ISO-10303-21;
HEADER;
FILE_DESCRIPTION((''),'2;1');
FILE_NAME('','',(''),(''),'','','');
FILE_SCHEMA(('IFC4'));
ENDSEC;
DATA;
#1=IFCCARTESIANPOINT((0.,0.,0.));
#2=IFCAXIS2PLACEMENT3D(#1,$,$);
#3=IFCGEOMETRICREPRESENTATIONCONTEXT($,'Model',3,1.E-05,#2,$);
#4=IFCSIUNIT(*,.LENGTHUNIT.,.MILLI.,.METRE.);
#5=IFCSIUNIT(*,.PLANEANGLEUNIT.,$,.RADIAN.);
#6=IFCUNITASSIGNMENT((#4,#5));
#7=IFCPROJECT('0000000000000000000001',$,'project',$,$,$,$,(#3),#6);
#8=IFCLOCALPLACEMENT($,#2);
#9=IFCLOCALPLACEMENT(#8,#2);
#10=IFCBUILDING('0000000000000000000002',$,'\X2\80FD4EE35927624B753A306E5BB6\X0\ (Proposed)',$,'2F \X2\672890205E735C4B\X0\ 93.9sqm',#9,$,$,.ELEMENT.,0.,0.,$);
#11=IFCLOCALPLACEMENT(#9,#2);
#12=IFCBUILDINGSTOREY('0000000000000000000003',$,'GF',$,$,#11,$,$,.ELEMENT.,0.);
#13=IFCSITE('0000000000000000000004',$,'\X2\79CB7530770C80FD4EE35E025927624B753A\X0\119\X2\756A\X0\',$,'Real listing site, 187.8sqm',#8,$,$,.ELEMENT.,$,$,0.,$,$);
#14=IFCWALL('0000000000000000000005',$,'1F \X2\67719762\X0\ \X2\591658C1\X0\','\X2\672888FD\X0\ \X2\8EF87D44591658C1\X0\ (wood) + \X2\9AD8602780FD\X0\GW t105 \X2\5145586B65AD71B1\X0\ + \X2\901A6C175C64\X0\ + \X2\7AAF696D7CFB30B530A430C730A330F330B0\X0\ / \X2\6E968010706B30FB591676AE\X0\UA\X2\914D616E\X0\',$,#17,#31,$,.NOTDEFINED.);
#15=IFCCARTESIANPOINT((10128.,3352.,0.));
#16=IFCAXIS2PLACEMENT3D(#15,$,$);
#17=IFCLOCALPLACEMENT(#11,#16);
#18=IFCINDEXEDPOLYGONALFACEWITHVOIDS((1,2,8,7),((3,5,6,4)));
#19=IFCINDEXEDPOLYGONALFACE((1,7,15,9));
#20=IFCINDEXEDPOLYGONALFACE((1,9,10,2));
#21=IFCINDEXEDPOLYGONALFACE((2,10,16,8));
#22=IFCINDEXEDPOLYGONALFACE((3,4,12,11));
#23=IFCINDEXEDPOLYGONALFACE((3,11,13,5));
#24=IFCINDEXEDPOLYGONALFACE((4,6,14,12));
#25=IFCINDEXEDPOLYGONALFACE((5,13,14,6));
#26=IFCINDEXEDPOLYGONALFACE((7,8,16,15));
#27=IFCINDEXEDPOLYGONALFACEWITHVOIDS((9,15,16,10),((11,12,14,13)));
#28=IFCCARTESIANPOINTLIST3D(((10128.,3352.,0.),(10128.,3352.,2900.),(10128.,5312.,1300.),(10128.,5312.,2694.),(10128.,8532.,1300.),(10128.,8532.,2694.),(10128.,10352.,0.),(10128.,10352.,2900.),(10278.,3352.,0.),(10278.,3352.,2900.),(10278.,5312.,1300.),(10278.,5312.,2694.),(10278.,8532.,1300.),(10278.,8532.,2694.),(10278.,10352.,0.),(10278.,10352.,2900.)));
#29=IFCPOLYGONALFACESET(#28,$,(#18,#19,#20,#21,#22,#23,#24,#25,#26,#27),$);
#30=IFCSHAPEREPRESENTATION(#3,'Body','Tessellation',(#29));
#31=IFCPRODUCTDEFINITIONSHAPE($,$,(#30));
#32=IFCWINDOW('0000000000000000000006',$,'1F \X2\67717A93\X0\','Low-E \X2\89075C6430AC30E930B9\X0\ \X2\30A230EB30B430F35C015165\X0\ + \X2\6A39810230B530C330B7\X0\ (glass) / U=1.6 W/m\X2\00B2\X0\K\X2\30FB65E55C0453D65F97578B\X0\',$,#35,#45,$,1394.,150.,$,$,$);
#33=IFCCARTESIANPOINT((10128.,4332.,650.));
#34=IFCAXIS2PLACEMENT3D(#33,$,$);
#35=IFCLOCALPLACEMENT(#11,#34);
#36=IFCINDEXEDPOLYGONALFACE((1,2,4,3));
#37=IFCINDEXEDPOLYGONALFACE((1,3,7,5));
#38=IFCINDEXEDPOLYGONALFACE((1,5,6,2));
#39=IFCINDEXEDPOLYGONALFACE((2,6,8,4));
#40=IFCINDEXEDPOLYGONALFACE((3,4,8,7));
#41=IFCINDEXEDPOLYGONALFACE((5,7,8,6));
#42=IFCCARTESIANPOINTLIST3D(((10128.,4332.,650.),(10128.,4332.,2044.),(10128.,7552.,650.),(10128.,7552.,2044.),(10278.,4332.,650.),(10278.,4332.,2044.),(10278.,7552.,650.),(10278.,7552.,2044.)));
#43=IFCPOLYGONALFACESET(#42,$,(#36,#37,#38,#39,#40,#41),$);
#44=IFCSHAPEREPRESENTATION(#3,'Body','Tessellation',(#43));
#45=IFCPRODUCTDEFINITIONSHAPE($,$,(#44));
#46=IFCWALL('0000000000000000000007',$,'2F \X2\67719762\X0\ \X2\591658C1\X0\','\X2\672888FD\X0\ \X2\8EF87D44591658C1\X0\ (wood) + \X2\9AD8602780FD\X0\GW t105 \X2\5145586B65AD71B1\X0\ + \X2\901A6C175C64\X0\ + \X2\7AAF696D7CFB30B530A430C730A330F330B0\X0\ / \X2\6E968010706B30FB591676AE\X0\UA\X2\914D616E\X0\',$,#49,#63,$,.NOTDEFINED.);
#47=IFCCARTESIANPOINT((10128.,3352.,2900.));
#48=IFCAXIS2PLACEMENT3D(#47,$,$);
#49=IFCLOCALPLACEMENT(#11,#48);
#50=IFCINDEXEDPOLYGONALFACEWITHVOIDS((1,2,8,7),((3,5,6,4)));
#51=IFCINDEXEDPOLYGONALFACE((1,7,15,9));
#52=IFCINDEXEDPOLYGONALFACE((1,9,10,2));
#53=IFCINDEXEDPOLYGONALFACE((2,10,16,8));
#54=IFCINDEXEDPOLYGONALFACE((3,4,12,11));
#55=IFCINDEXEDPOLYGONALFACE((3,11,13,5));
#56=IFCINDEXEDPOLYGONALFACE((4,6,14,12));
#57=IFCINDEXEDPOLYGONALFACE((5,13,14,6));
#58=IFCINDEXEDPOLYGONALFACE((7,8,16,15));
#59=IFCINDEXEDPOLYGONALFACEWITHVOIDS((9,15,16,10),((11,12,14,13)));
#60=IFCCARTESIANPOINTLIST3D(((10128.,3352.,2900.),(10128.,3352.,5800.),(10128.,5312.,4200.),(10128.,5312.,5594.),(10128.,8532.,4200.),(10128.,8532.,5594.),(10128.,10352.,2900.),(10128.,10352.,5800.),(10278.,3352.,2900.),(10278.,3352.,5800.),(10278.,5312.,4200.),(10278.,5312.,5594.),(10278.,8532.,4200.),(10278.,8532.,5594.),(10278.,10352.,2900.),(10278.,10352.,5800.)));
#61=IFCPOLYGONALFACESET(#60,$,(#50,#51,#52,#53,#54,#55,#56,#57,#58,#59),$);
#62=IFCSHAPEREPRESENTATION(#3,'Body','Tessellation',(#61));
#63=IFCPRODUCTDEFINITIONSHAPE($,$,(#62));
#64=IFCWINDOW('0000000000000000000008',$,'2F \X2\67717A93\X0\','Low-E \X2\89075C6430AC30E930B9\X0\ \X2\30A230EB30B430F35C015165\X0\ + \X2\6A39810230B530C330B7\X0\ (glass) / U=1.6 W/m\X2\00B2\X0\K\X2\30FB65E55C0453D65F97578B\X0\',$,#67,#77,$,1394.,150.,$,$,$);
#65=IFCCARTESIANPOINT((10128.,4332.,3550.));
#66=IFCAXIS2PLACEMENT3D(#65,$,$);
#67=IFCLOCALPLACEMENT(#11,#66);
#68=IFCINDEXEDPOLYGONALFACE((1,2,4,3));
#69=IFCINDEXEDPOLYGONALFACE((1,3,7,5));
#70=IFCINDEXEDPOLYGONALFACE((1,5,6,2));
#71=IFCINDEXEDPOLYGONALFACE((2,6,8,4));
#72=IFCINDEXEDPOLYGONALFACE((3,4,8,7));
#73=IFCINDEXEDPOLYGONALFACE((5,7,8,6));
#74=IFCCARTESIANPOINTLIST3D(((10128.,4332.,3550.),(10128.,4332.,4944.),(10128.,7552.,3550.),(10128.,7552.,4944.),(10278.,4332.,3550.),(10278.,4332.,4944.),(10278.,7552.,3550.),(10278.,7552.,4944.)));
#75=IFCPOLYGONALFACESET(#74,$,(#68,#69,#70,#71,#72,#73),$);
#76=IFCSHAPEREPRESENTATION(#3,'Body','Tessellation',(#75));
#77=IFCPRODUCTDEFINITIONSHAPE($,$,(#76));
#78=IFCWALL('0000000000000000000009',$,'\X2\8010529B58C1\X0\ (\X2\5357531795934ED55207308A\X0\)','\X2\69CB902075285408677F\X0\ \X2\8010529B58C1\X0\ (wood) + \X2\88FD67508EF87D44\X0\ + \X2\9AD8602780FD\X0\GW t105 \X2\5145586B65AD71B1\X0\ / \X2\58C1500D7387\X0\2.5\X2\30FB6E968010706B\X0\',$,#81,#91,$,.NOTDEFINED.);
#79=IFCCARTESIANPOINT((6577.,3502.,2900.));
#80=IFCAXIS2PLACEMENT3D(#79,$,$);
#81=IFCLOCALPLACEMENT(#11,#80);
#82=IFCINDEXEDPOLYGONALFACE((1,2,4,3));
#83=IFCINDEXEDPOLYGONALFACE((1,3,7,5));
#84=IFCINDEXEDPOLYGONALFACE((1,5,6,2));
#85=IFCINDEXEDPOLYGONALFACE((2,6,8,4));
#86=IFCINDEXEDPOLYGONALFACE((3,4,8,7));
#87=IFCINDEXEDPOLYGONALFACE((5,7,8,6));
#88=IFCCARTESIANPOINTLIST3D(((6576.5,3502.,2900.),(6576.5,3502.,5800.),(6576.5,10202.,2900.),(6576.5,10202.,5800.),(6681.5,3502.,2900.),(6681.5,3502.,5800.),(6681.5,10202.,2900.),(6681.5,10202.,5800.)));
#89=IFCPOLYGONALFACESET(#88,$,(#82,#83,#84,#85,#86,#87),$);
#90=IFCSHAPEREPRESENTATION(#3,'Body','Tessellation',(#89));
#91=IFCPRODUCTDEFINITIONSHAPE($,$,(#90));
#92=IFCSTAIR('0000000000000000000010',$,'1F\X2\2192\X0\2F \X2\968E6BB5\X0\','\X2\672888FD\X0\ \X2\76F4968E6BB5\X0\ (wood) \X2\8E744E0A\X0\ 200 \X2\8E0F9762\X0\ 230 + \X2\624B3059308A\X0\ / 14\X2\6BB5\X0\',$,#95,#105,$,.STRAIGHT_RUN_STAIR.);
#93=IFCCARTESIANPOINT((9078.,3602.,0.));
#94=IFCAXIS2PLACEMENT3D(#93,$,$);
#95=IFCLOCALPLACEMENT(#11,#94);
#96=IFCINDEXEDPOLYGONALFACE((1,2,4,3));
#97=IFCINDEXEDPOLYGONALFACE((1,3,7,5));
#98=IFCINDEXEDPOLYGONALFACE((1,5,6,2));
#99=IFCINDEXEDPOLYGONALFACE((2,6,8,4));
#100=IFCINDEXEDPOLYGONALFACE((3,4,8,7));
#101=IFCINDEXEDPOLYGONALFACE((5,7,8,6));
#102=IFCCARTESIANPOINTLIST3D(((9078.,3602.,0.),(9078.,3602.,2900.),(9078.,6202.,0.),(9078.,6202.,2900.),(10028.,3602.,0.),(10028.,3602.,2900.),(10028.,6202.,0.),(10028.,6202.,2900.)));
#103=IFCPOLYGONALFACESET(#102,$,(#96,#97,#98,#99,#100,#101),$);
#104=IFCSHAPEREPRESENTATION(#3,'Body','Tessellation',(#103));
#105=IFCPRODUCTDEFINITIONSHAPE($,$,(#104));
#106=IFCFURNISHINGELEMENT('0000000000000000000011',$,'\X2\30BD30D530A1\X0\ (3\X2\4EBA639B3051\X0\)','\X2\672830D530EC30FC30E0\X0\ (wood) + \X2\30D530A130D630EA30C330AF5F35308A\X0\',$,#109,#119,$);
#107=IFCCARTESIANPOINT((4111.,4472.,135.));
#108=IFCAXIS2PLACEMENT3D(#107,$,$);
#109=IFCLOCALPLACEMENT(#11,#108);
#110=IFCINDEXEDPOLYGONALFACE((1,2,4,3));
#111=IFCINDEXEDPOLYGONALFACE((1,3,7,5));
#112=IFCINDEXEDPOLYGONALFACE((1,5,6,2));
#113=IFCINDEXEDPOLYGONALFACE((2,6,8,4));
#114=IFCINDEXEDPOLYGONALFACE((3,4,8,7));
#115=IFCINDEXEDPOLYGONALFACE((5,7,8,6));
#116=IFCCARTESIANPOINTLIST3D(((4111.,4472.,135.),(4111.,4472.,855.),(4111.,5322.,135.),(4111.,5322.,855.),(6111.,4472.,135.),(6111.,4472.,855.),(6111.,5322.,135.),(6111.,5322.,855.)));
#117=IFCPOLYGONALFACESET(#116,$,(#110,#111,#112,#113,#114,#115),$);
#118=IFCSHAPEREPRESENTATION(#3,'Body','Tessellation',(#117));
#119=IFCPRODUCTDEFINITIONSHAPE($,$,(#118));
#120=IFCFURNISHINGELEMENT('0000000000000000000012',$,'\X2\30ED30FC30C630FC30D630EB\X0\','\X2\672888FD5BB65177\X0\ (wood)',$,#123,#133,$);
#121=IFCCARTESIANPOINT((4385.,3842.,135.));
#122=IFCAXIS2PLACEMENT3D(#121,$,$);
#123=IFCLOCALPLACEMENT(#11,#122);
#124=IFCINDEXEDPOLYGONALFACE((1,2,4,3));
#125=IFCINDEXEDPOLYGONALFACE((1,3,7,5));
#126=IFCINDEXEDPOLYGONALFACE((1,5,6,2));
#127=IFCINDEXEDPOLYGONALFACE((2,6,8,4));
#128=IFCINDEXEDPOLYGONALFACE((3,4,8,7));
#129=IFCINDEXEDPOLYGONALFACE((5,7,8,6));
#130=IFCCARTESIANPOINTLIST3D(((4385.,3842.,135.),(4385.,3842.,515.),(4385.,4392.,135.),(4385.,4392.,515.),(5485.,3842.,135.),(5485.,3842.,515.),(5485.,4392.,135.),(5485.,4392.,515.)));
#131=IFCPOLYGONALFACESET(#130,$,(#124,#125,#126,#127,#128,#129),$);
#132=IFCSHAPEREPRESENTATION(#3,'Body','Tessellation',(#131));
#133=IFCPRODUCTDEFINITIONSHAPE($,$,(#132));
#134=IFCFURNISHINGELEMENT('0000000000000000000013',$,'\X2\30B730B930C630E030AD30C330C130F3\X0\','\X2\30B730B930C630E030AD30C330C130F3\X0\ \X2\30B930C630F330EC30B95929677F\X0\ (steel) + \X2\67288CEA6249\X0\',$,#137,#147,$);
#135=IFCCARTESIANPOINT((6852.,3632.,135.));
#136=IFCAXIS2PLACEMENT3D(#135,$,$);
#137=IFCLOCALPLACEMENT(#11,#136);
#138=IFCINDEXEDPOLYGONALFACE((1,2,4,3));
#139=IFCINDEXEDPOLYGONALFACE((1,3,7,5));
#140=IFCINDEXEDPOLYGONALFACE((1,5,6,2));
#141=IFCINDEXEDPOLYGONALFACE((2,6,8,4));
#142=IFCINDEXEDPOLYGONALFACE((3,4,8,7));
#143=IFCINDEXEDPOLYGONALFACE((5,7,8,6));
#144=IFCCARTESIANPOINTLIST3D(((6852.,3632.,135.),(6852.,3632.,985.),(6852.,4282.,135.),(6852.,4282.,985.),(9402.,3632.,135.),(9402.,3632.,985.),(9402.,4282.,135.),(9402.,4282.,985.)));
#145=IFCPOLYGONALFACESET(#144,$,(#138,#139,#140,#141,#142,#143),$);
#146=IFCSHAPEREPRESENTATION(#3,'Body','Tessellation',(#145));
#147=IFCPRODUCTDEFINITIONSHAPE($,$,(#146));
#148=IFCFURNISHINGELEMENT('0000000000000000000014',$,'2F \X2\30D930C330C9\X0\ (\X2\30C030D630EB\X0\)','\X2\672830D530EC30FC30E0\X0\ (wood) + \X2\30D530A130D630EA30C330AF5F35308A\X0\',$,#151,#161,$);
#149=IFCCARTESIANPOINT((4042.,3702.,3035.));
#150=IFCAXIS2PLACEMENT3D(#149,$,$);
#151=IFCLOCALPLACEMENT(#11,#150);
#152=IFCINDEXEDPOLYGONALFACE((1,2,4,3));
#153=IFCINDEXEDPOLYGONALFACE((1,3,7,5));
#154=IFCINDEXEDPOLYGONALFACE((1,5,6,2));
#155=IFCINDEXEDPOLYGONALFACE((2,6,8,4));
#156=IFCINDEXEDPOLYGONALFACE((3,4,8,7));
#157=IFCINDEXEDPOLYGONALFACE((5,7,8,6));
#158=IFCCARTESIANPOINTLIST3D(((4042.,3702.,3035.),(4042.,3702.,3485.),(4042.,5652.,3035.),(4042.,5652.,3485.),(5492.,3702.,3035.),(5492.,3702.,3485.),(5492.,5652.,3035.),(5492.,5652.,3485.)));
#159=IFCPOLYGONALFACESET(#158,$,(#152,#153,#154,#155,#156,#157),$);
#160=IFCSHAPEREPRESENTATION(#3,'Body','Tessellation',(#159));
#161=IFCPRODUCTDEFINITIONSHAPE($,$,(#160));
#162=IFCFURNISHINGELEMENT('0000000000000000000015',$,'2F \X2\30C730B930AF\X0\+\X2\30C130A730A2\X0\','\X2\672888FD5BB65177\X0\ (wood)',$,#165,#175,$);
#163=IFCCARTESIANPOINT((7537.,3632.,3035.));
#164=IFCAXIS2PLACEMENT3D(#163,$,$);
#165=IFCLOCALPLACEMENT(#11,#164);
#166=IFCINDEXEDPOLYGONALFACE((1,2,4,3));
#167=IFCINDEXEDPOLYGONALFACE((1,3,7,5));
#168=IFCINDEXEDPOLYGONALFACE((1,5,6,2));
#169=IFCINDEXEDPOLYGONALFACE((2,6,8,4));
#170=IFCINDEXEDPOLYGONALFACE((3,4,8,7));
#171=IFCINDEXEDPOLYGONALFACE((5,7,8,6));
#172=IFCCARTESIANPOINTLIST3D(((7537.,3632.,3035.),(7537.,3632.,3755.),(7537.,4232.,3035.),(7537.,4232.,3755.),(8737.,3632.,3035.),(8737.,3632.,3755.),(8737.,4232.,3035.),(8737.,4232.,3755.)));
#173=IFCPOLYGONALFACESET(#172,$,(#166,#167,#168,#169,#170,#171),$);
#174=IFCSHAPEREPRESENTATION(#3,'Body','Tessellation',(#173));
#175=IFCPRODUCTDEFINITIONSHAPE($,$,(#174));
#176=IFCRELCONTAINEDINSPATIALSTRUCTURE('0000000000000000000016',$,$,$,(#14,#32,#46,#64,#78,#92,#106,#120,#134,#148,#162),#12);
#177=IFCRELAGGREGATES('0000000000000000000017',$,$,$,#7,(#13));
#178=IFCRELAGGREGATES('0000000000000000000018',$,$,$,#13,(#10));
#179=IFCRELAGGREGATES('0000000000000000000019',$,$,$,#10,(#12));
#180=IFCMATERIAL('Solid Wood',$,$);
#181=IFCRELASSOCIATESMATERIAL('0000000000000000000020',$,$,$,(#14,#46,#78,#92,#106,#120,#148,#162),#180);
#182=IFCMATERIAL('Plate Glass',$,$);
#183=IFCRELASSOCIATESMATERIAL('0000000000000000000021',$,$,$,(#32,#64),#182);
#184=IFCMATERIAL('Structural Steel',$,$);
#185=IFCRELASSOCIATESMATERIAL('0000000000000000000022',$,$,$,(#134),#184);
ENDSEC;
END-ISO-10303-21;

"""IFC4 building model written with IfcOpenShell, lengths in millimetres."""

from ifc_helpers import new_model, si_unit, frame, frame_2d, origin, place, context, project, spatial, rectangle, extrude, material, element, fill, save


model = new_model("IFC4")

# Units and contexts
model_context = context("Model", 3, precision=1e-05, world=origin())
ifc_project = project(units=[si_unit("LENGTHUNIT", "METRE", prefix="MILLI"), si_unit("PLANEANGLEUNIT", "RADIAN")], contexts=[model_context])

# Site, building, storey
site_placement = place(None, origin())
site = spatial("IfcSite", under=ifc_project, at=site_placement, Name="秋田県能代市大手町119番", ObjectType="Real listing site, 187.8sqm", CompositionType="ELEMENT", RefElevation=0.0)
building_placement = place(site_placement, origin())
building = spatial("IfcBuilding", under=site, at=building_placement, Name="能代大手町の家 (Proposed)", ObjectType="2F 木造平屋 93.9sqm", CompositionType="ELEMENT", ElevationOfRefHeight=0.0, ElevationOfTerrain=0.0)
storey_placement = place(building_placement, origin())
storey = spatial("IfcBuildingStorey", under=building, at=storey_placement, Name="GF", CompositionType="ELEMENT", Elevation=0.0)

# Wall, opening, window
ifc_material_1 = material(Name="Solid Wood")
wall_1_placement = place(storey_placement, frame((10128.0, 3352.0, 0.0)))
wall_1 = element("IfcWall", 1, at=wall_1_placement, inside=storey, material=ifc_material_1, Name="1F 東面 外壁", Description="木製 軸組外壁 (wood) + 高性能GW t105 充填断熱 + 通気層 + 窯業系サイディング / 準耐火・外皮UA配慮", PredefinedType="NOTDEFINED", context=model_context, shape_type="SweptSolid", body=[
    extrude(rectangle(XDim=150.0, YDim=7000.0, at=frame_2d((75.0, 3500.0))), frame((10128.0, 3352.0, 0.0)), (0.0, 0.0, 1.0), 2900.0),
])
opening_1_placement = place(storey_placement, frame((10128.0, 4332.0, 650.0)))
opening_1 = element("IfcOpeningElement", 2, at=opening_1_placement, cuts=wall_1, PredefinedType="NOTDEFINED", context=model_context, shape_type="SweptSolid", body=[
    extrude(rectangle(XDim=150.0, YDim=3220.0, at=frame_2d((75.0, 1610.0))), frame((10128.0, 4332.0, 650.0)), (0.0, 0.0, 1.0), 1394.0),
])
ifc_material_2 = material(Name="Plate Glass")
window_1_placement = place(storey_placement, frame((10128.0, 4332.0, 650.0)))
window_1 = element("IfcWindow", 3, at=window_1_placement, inside=storey, material=ifc_material_2, Name="1F 東窓", Description="Low-E 複層ガラス アルゴン封入 + 樹脂サッシ (glass) / U=1.6 W/m²K・日射取得型", OverallHeight=1394.0, OverallWidth=150.0, context=model_context, shape_type="SweptSolid", body=[
    extrude(rectangle(XDim=150.0, YDim=3220.0, at=frame_2d((75.0, 1610.0))), frame((10128.0, 4332.0, 650.0)), (0.0, 0.0, 1.0), 1394.0),
])
fill(opening_1, window_1)

# Wall, opening, window
wall_2_placement = place(storey_placement, frame((10128.0, 3352.0, 2900.0)))
wall_2 = element("IfcWall", 4, at=wall_2_placement, inside=storey, material=ifc_material_1, Name="2F 東面 外壁", Description="木製 軸組外壁 (wood) + 高性能GW t105 充填断熱 + 通気層 + 窯業系サイディング / 準耐火・外皮UA配慮", PredefinedType="NOTDEFINED", context=model_context, shape_type="SweptSolid", body=[
    extrude(rectangle(XDim=150.0, YDim=7000.0, at=frame_2d((75.0, 3500.0))), frame((10128.0, 3352.0, 2900.0)), (0.0, 0.0, 1.0), 2900.0),
])
opening_2_placement = place(storey_placement, frame((10128.0, 4332.0, 3550.0)))
opening_2 = element("IfcOpeningElement", 5, at=opening_2_placement, cuts=wall_2, PredefinedType="NOTDEFINED", context=model_context, shape_type="SweptSolid", body=[
    extrude(rectangle(XDim=150.0, YDim=3220.0, at=frame_2d((75.0, 1610.0))), frame((10128.0, 4332.0, 3550.0)), (0.0, 0.0, 1.0), 1394.0),
])
window_2_placement = place(storey_placement, frame((10128.0, 4332.0, 3550.0)))
window_2 = element("IfcWindow", 6, at=window_2_placement, inside=storey, material=ifc_material_2, Name="2F 東窓", Description="Low-E 複層ガラス アルゴン封入 + 樹脂サッシ (glass) / U=1.6 W/m²K・日射取得型", OverallHeight=1394.0, OverallWidth=150.0, context=model_context, shape_type="SweptSolid", body=[
    extrude(rectangle(XDim=150.0, YDim=3220.0, at=frame_2d((75.0, 1610.0))), frame((10128.0, 4332.0, 3550.0)), (0.0, 0.0, 1.0), 1394.0),
])
fill(opening_2, window_2)

# Wall
wall_3_placement = place(storey_placement, frame((6577.0, 3502.0, 2900.0)))
element("IfcWall", 7, at=wall_3_placement, inside=storey, material=ifc_material_1, Name="耐力壁 (南北間仕切り)", Description="構造用合板 耐力壁 (wood) + 製材軸組 + 高性能GW t105 充填断熱 / 壁倍率2.5・準耐火", PredefinedType="NOTDEFINED", context=model_context, shape_type="SweptSolid", body=[
    extrude(rectangle(XDim=105.0, YDim=6700.0, at=frame_2d((52.0, 3350.0))), frame((6577.0, 3502.0, 2900.0)), (0.0, 0.0, 1.0), 2900.0),
])

# Stair
stair_placement = place(storey_placement, frame((9078.0, 3602.0, 0.0)))
element("IfcStair", 8, at=stair_placement, inside=storey, material=ifc_material_1, Name="1F→2F 階段", Description="木製 直階段 (wood) 蹴上 200 踏面 230 + 手すり / 14段", PredefinedType="STRAIGHT_RUN_STAIR", context=model_context, shape_type="SweptSolid", body=[
    extrude(rectangle(XDim=950.0, YDim=2600.0, at=frame_2d((475.0, 1300.0))), frame((9078.0, 3602.0, 0.0)), (0.0, 0.0, 1.0), 2900.0),
])

# Furnishing elements
furnishing_1_placement = place(storey_placement, frame((4111.0, 4472.0, 135.0)))
element("IfcFurnishingElement", 9, at=furnishing_1_placement, inside=storey, material=ifc_material_1, Name="ソファ (3人掛け)", Description="木フレーム (wood) + ファブリック張り", context=model_context, shape_type="SweptSolid", body=[
    extrude(rectangle(XDim=2000.0, YDim=850.0, at=frame_2d((1000.0, 425.0))), frame((4111.0, 4472.0, 135.0)), (0.0, 0.0, 1.0), 720.0),
])
furnishing_2_placement = place(storey_placement, frame((4385.0, 3842.0, 135.0)))
element("IfcFurnishingElement", 10, at=furnishing_2_placement, inside=storey, material=ifc_material_1, Name="ローテーブル", Description="木製家具 (wood)", context=model_context, shape_type="SweptSolid", body=[
    extrude(rectangle(XDim=1100.0, YDim=550.0, at=frame_2d((550.0, 275.0))), frame((4385.0, 3842.0, 135.0)), (0.0, 0.0, 1.0), 380.0),
])
ifc_material_3 = material(Name="Structural Steel")
furnishing_3_placement = place(storey_placement, frame((6852.0, 3632.0, 135.0)))
element("IfcFurnishingElement", 11, at=furnishing_3_placement, inside=storey, material=ifc_material_3, Name="システムキッチン", Description="システムキッチン ステンレス天板 (steel) + 木質扉", context=model_context, shape_type="SweptSolid", body=[
    extrude(rectangle(XDim=2550.0, YDim=650.0, at=frame_2d((1275.0, 325.0))), frame((6852.0, 3632.0, 135.0)), (0.0, 0.0, 1.0), 850.0),
])
furnishing_4_placement = place(storey_placement, frame((4042.0, 3702.0, 3035.0)))
element("IfcFurnishingElement", 12, at=furnishing_4_placement, inside=storey, material=ifc_material_1, Name="2F ベッド (ダブル)", Description="木フレーム (wood) + ファブリック張り", context=model_context, shape_type="SweptSolid", body=[
    extrude(rectangle(XDim=1450.0, YDim=1950.0, at=frame_2d((725.0, 975.0))), frame((4042.0, 3702.0, 3035.0)), (0.0, 0.0, 1.0), 450.0),
])
furnishing_5_placement = place(storey_placement, frame((7537.0, 3632.0, 3035.0)))
element("IfcFurnishingElement", 13, at=furnishing_5_placement, inside=storey, material=ifc_material_1, Name="2F デスク+チェア", Description="木製家具 (wood)", context=model_context, shape_type="SweptSolid", body=[
    extrude(rectangle(XDim=1200.0, YDim=600.0, at=frame_2d((600.0, 300.0))), frame((7537.0, 3632.0, 3035.0)), (0.0, 0.0, 1.0), 720.0),
])

save(model, "model.ifc")
